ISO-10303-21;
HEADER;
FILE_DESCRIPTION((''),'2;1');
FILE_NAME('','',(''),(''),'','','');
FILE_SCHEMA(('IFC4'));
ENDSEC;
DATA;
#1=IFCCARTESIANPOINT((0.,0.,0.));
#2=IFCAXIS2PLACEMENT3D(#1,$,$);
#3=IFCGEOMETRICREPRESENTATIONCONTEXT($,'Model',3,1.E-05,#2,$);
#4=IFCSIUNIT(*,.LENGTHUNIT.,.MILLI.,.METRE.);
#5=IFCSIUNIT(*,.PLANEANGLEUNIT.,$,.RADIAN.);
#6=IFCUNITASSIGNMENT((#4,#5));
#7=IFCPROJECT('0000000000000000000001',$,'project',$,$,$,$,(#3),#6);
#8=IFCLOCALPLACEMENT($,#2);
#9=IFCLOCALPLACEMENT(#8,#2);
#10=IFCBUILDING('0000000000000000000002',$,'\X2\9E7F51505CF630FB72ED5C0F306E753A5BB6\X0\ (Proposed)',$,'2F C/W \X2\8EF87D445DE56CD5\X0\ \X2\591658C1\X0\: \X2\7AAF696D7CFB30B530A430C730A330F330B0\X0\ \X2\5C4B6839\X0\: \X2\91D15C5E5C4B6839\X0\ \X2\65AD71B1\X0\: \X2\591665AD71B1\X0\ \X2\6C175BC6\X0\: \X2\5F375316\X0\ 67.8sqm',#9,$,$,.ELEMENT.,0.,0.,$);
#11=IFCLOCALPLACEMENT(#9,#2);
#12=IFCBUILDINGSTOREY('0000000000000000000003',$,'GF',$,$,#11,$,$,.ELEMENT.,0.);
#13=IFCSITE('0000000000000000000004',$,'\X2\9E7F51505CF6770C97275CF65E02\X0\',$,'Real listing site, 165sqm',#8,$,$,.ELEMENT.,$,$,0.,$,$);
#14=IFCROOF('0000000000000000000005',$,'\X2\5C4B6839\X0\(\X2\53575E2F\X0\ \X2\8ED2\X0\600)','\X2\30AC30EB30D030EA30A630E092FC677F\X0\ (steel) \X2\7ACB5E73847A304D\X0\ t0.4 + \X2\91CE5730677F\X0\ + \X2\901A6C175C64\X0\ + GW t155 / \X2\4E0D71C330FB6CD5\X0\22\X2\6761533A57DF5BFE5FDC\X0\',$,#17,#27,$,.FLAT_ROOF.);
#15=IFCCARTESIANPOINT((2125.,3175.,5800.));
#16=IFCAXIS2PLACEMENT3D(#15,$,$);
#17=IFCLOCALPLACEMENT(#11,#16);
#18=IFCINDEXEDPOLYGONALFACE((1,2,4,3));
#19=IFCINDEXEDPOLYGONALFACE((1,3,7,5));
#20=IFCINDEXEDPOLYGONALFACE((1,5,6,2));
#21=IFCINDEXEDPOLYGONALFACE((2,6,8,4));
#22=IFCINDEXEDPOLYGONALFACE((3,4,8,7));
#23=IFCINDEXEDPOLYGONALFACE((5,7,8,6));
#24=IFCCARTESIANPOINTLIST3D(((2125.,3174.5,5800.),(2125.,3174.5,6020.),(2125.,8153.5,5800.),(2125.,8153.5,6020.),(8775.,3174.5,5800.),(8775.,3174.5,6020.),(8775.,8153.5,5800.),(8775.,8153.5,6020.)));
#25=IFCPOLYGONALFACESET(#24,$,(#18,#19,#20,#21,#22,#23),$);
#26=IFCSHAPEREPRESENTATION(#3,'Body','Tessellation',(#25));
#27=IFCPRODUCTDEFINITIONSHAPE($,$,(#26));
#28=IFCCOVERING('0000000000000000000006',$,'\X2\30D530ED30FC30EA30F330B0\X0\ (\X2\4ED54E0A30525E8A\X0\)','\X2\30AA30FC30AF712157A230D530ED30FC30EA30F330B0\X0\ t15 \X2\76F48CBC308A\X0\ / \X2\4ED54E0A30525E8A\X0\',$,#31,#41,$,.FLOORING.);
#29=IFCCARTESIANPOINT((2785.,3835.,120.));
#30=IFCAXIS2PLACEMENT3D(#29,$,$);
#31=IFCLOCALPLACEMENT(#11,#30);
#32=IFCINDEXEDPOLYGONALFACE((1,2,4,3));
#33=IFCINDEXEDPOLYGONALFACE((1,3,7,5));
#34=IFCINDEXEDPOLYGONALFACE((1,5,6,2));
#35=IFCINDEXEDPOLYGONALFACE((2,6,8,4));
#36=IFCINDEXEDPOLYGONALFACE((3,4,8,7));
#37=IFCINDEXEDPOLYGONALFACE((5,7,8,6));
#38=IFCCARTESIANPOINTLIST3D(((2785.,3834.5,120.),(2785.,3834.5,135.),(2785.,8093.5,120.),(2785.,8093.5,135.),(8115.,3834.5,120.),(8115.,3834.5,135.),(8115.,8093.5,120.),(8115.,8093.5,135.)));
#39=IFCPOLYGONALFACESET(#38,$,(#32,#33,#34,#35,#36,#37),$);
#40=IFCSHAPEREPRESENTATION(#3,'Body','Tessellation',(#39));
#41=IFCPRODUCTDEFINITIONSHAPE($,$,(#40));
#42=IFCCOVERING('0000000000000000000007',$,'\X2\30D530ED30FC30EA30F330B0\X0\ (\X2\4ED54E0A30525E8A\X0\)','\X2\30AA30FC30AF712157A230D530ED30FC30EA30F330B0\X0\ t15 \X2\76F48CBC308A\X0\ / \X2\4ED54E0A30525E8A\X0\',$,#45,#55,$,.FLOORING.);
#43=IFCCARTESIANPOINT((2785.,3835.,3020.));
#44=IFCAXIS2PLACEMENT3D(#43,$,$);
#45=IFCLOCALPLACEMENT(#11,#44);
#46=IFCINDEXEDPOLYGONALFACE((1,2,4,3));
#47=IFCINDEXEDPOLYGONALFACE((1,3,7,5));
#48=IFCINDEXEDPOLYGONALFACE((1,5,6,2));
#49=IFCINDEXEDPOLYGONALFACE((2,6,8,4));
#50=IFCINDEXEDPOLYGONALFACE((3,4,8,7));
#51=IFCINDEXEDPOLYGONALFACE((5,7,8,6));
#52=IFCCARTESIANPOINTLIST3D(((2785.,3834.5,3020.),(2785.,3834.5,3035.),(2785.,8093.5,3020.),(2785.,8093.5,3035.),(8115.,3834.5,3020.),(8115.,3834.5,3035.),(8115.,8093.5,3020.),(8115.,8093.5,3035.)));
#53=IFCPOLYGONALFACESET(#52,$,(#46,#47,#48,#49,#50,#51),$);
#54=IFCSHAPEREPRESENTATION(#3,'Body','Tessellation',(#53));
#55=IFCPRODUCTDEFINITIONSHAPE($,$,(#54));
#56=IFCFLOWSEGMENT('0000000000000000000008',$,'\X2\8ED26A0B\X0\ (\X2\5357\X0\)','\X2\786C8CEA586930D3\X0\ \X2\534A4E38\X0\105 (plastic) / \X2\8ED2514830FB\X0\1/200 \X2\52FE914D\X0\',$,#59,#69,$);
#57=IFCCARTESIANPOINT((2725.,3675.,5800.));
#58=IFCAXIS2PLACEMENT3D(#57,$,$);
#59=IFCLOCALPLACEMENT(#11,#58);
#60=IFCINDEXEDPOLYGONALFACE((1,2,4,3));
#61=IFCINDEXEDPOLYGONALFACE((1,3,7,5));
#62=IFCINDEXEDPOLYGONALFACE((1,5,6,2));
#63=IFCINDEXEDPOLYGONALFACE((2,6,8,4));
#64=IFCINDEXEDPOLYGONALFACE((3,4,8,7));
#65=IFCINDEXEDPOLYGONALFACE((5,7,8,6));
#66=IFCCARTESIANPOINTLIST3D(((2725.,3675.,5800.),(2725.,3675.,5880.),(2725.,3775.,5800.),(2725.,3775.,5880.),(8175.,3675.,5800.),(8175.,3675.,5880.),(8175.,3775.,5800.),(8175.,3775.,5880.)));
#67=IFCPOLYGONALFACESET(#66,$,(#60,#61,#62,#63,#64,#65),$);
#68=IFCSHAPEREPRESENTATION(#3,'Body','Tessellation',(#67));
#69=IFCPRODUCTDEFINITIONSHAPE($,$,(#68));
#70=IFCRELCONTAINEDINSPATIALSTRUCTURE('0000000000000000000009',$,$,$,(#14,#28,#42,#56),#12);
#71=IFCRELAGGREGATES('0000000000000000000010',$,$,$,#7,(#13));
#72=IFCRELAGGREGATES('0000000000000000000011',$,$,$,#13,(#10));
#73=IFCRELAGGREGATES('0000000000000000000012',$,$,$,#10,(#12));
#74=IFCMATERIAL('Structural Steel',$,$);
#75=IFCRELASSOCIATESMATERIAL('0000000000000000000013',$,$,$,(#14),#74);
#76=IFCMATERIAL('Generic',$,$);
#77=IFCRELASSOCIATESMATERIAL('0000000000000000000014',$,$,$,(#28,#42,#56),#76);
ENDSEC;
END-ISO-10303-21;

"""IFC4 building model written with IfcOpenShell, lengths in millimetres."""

from ifc_helpers import new_model, si_unit, frame, frame_2d, origin, place, context, project, spatial, rectangle, extrude, material, element, save


model = new_model("IFC4")

# Units and contexts
model_context = context("Model", 3, precision=1e-05, world=origin())
ifc_project = project(units=[si_unit("LENGTHUNIT", "METRE", prefix="MILLI"), si_unit("PLANEANGLEUNIT", "RADIAN")], contexts=[model_context])

# Site, building, storey
site_placement = place(None, origin())
site = spatial("IfcSite", under=ifc_project, at=site_placement, Name="鹿児島県霧島市", ObjectType="Real listing site, 165sqm", CompositionType="ELEMENT", RefElevation=0.0)
building_placement = place(site_placement, origin())
building = spatial("IfcBuilding", under=site, at=building_placement, Name="鹿児島・狭小の町家 (Proposed)", ObjectType="2F C/W 軸組工法 外壁: 窯業系サイディング 屋根: 金属屋根 断熱: 外断熱 気密: 強化 67.8sqm", CompositionType="ELEMENT", ElevationOfRefHeight=0.0, ElevationOfTerrain=0.0)
storey_placement = place(building_placement, origin())
storey = spatial("IfcBuildingStorey", under=building, at=storey_placement, Name="GF", CompositionType="ELEMENT", Elevation=0.0)

# Roof
ifc_material_1 = material(Name="Structural Steel")
for number, where, name in (
    (1, (2125.0, 3175.0, 5800.0), "屋根(南帯 軒600)"),
):
    element("IfcRoof", number, at=place(storey_placement, frame(where)), inside=storey, material=ifc_material_1, Name=name, Description="ガルバリウム鋼板 (steel) 立平葺き t0.4 + 野地板 + 通気層 + GW t155 / 不燃・法22条区域対応", PredefinedType="FLAT_ROOF", context=model_context, shape_type="SweptSolid", body=[
        extrude(rectangle(XDim=6650.0, YDim=4979.0, at=frame_2d((3325.0, 2489.0))), frame((2125.0, 3175.0, 5800.0)), (0.0, 0.0, 1.0), 220.0),
    ])

# Coverings
ifc_material_2 = material(Name="Generic")
covering_1_placement = place(storey_placement, frame((2785.0, 3835.0, 120.0)))
element("IfcCovering", 2, at=covering_1_placement, inside=storey, material=ifc_material_2, Name="フローリング (仕上げ床)", Description="オーク無垢フローリング t15 直貼り / 仕上げ床", PredefinedType="FLOORING", context=model_context, shape_type="SweptSolid", body=[
    extrude(rectangle(XDim=5330.0, YDim=4259.0, at=frame_2d((2665.0, 2129.0))), frame((2785.0, 3835.0, 120.0)), (0.0, 0.0, 1.0), 15.0),
])
covering_2_placement = place(storey_placement, frame((2785.0, 3835.0, 3020.0)))
element("IfcCovering", 3, at=covering_2_placement, inside=storey, material=ifc_material_2, Name="フローリング (仕上げ床)", Description="オーク無垢フローリング t15 直貼り / 仕上げ床", PredefinedType="FLOORING", context=model_context, shape_type="SweptSolid", body=[
    extrude(rectangle(XDim=5330.0, YDim=4259.0, at=frame_2d((2665.0, 2129.0))), frame((2785.0, 3835.0, 3020.0)), (0.0, 0.0, 1.0), 15.0),
])

# Flow segment
flow_segment_placement = place(storey_placement, frame((2725.0, 3675.0, 5800.0)))
element("IfcFlowSegment", 4, at=flow_segment_placement, inside=storey, material=ifc_material_2, Name="軒樋 (南)", Description="硬質塩ビ 半丸105 (plastic) / 軒先・1/200 勾配", context=model_context, shape_type="SweptSolid", body=[
    extrude(rectangle(XDim=5450.0, YDim=100.0, at=frame_2d((2725.0, 50.0))), frame((2725.0, 3675.0, 5800.0)), (0.0, 0.0, 1.0), 80.0),
])

save(model, "model.ifc")
